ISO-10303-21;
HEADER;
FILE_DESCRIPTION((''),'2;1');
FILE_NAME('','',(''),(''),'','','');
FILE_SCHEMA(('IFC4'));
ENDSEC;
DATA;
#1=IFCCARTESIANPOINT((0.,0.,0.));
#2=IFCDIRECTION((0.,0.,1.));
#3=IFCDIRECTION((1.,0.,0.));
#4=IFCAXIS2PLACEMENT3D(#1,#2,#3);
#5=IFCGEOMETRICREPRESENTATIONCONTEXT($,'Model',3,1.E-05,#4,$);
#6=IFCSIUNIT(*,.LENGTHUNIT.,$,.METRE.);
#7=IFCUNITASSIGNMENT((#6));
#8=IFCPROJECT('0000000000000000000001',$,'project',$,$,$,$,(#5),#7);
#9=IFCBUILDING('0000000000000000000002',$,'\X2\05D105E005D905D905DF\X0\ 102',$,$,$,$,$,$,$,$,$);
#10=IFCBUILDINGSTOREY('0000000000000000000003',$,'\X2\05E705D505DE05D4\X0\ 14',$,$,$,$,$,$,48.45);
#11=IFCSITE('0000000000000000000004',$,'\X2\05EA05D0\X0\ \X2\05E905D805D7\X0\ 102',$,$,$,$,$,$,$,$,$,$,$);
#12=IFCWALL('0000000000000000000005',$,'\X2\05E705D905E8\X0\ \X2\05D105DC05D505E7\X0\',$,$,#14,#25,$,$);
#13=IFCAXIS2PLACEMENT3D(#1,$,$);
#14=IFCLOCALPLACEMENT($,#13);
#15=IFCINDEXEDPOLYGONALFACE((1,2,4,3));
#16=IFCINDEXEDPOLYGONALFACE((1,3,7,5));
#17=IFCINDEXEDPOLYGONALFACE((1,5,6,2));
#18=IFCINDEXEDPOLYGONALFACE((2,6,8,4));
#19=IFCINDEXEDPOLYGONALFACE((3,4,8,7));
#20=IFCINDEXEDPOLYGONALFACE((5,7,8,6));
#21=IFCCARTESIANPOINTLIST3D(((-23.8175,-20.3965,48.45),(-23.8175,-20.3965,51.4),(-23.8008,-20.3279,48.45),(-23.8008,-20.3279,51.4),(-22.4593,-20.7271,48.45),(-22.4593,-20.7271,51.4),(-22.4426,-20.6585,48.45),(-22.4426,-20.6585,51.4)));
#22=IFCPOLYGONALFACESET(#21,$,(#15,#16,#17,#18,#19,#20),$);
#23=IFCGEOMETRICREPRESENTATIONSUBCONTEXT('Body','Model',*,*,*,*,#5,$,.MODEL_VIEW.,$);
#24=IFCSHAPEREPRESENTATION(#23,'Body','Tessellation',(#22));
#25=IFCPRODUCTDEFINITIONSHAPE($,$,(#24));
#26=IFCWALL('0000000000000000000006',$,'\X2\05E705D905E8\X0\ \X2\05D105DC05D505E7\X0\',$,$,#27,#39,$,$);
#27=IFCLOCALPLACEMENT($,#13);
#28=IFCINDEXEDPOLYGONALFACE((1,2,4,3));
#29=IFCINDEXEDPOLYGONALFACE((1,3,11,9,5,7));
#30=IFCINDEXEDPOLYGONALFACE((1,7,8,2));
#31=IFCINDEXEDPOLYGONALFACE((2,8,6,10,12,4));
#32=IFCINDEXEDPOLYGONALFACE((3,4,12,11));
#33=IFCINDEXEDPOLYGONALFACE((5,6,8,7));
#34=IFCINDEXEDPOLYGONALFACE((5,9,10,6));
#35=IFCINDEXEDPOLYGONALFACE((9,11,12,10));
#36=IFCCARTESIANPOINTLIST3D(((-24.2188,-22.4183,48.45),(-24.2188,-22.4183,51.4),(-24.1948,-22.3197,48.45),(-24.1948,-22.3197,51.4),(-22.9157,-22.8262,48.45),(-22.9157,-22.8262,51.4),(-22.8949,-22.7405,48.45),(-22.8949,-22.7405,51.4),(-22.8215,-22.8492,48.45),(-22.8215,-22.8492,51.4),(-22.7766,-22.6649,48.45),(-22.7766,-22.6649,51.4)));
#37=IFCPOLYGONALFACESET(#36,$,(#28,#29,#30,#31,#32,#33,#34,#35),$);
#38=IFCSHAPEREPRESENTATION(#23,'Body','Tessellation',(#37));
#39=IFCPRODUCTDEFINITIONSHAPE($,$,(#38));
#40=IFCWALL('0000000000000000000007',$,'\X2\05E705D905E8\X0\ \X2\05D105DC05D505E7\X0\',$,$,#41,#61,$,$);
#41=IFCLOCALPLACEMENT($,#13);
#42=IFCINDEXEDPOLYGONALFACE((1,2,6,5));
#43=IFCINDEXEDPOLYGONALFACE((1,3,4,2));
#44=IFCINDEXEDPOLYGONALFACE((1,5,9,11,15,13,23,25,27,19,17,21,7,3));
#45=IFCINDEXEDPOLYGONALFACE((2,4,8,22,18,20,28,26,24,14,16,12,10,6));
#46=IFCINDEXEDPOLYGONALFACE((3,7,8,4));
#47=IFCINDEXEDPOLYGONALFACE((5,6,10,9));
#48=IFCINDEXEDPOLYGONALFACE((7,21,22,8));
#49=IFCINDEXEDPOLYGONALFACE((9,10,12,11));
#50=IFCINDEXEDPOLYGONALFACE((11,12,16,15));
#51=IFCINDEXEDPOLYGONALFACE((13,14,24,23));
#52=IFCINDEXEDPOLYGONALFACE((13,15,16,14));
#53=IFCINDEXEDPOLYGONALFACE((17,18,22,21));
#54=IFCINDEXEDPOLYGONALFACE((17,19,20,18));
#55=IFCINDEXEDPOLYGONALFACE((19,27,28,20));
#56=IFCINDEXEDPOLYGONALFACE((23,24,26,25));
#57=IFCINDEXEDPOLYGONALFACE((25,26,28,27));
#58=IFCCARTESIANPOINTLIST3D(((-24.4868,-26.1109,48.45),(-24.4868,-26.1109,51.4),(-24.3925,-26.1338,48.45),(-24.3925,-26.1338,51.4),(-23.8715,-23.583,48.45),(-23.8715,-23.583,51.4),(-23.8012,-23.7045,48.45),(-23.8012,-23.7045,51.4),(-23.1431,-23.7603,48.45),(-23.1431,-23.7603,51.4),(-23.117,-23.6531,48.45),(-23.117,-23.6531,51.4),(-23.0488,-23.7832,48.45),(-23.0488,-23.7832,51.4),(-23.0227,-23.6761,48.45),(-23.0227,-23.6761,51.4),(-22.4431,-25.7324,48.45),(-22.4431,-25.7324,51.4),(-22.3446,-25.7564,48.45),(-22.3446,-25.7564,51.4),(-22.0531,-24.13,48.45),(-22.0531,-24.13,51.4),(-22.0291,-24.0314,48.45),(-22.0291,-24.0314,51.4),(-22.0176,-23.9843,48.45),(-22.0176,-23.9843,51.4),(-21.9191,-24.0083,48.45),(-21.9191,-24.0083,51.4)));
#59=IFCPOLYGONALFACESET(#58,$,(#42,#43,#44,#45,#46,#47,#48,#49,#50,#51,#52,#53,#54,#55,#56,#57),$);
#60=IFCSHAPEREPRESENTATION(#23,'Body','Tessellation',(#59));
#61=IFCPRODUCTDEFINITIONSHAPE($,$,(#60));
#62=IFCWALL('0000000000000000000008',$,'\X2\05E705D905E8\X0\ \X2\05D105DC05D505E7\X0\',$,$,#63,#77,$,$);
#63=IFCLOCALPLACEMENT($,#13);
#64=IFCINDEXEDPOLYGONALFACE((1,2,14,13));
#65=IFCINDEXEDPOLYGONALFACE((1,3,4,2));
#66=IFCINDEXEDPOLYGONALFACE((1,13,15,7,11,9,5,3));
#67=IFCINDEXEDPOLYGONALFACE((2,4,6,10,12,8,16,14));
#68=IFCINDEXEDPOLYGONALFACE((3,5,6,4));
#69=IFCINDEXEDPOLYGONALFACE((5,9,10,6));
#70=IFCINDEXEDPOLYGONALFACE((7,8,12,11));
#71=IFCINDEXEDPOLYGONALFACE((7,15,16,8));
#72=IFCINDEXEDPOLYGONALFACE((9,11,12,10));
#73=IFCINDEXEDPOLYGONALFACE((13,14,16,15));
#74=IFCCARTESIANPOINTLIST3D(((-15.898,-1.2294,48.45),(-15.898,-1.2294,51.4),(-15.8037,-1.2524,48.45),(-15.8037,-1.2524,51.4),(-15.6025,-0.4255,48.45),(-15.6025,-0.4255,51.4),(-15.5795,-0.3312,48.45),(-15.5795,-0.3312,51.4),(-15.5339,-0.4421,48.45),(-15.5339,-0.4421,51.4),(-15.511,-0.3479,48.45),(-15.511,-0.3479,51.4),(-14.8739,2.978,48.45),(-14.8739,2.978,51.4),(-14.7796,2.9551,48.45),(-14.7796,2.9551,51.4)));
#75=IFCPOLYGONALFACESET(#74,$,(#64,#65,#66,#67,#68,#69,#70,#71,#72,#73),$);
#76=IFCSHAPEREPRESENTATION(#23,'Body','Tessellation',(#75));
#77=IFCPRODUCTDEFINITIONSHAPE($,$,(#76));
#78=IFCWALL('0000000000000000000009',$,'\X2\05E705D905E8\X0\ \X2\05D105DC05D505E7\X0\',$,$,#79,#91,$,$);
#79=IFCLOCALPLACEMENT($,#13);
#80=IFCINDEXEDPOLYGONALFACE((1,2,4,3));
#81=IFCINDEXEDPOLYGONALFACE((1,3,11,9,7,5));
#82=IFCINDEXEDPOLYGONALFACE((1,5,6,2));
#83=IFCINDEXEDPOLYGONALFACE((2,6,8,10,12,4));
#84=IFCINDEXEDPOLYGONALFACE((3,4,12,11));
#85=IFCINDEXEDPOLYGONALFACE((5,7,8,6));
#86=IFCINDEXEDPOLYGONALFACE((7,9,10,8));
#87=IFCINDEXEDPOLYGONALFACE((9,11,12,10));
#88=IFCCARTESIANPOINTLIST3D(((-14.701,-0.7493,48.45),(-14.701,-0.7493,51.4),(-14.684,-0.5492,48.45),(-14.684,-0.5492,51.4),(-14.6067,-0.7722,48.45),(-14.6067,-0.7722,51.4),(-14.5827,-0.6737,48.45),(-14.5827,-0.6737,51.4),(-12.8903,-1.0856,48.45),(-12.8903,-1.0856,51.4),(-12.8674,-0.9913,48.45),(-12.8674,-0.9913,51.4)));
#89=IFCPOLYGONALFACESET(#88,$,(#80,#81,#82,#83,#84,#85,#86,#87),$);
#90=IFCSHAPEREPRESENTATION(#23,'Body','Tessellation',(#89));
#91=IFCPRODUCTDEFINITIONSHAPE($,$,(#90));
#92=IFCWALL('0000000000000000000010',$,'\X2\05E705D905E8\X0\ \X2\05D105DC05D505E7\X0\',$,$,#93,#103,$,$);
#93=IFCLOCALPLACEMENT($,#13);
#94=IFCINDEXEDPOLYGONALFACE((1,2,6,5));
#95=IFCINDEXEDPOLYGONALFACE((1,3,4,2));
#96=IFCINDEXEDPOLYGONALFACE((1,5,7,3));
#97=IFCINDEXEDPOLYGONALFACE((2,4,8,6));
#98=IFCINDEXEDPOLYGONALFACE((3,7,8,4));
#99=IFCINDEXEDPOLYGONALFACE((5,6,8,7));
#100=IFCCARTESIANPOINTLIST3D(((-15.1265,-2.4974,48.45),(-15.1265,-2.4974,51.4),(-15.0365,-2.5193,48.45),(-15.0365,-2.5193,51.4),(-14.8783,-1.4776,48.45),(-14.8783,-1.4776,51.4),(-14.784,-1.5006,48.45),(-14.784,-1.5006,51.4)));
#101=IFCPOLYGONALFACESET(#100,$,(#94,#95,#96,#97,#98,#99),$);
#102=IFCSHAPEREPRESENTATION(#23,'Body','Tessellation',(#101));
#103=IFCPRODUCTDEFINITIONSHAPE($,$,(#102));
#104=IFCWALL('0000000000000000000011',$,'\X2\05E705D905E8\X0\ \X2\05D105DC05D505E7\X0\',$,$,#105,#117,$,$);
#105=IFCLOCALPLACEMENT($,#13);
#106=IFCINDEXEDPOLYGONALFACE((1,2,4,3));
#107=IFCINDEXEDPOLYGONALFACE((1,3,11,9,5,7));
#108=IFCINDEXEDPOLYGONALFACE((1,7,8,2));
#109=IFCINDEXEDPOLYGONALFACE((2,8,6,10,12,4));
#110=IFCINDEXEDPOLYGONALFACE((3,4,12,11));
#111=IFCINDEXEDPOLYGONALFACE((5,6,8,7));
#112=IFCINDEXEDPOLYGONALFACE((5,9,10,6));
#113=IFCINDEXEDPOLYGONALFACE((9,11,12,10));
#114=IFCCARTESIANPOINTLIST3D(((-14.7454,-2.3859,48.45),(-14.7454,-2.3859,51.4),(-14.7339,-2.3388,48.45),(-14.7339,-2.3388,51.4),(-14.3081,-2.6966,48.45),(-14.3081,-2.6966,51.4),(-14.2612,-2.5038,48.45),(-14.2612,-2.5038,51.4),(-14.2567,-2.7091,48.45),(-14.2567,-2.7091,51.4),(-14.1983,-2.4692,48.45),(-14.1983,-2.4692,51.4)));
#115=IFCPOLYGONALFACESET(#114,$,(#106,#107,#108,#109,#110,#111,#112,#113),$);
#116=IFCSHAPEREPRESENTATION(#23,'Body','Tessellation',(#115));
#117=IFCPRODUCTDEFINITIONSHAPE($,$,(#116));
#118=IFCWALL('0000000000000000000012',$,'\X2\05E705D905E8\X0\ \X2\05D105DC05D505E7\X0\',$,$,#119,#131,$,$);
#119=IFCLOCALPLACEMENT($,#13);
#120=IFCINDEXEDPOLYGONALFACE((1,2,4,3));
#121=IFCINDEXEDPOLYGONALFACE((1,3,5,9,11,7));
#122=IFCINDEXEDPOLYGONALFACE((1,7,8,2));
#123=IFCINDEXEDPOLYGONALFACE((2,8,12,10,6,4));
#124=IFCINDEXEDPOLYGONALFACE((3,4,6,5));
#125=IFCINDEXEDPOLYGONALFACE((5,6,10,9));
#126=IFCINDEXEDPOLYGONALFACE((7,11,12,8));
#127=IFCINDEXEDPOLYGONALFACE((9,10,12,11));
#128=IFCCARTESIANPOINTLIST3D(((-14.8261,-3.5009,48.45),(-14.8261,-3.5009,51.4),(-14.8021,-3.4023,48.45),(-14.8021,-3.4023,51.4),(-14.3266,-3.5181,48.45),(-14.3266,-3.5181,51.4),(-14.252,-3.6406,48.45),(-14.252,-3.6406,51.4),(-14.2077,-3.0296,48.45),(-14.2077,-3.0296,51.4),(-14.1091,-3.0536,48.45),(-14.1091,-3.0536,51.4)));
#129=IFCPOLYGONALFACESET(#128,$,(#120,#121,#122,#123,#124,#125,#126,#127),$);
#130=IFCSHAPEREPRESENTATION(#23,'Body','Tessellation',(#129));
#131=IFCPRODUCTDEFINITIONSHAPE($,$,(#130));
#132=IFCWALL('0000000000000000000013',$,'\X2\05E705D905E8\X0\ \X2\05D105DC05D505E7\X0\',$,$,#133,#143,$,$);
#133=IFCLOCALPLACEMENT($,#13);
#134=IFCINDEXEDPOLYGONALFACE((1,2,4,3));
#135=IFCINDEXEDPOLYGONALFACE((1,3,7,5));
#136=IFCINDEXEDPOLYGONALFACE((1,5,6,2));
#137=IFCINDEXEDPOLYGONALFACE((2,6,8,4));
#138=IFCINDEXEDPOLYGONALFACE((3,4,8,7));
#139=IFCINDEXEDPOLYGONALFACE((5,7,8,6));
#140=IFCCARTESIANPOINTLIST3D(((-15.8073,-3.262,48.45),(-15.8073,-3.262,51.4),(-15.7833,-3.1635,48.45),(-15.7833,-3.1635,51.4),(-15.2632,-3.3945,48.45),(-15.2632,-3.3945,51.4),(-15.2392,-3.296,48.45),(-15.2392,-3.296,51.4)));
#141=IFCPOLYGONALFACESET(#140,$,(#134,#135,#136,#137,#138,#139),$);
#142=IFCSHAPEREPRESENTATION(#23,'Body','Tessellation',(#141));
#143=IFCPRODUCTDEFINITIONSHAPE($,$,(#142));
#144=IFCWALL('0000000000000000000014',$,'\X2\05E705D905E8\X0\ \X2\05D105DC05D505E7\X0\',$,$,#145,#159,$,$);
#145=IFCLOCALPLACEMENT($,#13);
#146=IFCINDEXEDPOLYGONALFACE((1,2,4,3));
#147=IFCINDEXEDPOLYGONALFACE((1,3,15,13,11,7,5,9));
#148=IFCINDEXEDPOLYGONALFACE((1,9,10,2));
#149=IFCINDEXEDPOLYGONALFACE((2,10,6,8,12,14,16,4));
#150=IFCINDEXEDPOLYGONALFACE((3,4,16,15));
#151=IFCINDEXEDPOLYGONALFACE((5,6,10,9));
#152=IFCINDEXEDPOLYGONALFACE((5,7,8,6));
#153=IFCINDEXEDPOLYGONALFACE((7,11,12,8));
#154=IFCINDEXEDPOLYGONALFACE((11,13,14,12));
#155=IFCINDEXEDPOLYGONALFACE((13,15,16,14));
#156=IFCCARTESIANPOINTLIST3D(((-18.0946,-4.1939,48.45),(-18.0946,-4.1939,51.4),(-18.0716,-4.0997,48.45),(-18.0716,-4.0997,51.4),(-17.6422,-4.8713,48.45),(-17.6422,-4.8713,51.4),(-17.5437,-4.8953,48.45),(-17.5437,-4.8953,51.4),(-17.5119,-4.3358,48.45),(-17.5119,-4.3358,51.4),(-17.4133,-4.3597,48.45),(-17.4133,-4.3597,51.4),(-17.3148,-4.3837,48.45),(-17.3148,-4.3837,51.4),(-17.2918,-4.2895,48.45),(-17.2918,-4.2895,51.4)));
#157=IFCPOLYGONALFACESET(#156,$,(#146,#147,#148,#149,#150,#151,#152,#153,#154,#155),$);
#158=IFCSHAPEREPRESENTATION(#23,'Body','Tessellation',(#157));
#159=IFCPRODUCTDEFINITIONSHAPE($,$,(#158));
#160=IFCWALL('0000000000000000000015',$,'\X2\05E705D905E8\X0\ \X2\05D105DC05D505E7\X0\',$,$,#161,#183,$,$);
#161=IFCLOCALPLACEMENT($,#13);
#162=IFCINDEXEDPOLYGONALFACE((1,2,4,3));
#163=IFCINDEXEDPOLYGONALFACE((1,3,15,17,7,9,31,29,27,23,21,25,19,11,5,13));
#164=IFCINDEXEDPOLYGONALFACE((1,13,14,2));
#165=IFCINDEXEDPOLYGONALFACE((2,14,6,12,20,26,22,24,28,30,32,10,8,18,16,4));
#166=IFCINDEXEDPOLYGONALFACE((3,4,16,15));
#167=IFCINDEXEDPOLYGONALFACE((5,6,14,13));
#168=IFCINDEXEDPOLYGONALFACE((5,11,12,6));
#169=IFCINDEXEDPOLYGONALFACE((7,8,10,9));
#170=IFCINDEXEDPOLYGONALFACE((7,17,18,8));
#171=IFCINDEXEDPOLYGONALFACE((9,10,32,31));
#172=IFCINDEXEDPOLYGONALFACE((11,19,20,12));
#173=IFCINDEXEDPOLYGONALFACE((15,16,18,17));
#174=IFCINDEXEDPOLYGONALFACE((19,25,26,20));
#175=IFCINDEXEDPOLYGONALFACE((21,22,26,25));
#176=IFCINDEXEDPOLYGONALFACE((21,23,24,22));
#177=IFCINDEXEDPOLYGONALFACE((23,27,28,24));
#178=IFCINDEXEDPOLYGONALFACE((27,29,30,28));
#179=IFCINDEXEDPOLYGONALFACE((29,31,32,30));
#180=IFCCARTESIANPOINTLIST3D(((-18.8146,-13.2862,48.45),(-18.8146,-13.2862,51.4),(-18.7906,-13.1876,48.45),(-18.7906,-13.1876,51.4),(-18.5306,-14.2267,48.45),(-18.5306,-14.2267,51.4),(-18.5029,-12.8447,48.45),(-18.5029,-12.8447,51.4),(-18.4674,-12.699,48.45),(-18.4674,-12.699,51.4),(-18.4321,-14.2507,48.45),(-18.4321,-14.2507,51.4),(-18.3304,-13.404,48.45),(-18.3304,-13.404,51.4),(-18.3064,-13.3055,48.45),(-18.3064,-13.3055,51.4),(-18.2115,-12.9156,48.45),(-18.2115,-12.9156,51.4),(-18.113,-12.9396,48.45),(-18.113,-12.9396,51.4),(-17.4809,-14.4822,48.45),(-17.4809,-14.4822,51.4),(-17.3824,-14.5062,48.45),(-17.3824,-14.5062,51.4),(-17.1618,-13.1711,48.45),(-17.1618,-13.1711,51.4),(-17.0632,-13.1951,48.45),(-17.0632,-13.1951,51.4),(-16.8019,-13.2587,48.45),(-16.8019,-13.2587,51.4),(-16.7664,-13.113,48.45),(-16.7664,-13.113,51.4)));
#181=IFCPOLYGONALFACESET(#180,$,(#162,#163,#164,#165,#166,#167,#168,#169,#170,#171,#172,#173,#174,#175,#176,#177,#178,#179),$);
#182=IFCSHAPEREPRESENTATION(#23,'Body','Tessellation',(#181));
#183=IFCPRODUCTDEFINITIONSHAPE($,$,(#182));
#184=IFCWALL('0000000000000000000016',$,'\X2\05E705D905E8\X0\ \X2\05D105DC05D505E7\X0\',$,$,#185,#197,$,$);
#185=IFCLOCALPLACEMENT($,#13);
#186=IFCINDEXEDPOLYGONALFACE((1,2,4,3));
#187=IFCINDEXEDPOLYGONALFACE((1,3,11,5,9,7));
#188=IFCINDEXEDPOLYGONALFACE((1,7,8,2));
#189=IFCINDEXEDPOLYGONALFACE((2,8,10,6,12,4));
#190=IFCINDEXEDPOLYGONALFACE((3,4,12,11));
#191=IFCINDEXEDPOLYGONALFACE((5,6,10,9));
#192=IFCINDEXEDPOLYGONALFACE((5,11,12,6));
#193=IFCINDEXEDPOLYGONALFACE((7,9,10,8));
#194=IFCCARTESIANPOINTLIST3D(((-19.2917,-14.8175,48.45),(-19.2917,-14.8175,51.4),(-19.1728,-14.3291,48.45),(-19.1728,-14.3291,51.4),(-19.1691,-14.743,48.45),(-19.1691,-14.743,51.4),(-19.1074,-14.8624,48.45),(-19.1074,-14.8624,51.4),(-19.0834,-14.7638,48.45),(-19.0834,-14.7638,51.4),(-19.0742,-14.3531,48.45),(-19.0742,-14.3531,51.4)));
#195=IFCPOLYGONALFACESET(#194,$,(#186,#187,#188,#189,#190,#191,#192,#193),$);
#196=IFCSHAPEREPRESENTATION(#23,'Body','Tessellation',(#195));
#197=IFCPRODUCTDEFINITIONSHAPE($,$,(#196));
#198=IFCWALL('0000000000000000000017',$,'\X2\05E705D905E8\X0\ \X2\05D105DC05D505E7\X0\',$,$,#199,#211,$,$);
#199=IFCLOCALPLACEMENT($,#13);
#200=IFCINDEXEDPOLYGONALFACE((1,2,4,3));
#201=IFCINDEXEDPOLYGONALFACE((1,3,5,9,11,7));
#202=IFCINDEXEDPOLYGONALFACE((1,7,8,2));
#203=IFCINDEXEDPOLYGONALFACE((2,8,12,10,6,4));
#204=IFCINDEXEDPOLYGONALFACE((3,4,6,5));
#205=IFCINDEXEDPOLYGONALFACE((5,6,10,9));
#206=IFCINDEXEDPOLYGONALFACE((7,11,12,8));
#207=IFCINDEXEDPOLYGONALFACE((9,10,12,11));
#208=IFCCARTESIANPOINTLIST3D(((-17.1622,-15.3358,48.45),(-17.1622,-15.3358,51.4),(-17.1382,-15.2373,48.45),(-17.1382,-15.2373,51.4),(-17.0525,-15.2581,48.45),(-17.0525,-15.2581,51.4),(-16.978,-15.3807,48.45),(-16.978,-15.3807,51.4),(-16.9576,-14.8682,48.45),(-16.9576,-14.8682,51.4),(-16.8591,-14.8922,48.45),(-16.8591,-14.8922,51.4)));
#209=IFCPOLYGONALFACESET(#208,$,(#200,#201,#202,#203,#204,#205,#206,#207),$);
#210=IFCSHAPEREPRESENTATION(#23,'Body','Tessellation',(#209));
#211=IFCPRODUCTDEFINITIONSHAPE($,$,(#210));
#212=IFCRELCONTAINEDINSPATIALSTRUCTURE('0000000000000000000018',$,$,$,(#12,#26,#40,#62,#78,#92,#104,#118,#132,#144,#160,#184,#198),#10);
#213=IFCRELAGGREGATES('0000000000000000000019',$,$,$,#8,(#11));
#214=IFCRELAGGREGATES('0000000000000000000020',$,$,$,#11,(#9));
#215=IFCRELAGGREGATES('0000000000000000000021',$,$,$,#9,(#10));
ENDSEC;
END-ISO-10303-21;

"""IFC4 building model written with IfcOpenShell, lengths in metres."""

from ifc_helpers import new_model, si_unit, frame, origin_with_axes, context, subcontext, project, spatial, polyline, outline, extrude, element, save


model = new_model("IFC4")

# Units and contexts
model_context = context("Model", 3, precision=1e-05, world=origin_with_axes())
body_context = subcontext(model_context, "Body", "Model", "MODEL_VIEW")
ifc_project = project(units=[si_unit("LENGTHUNIT", "METRE")], contexts=[model_context])

# Site, building, storey
site = spatial("IfcSite", under=ifc_project, Name="תא שטח 102")
building = spatial("IfcBuilding", under=site, Name="בניין 102")
storey = spatial("IfcBuildingStorey", under=building, Name="קומה 14", Elevation=48.45)

# Walls
element("IfcWall", 1, inside=storey, Name="קיר בלוק", context=body_context, shape_type="SweptSolid", body=[
    extrude(outline(polyline([(-22.4426, -20.6585), (-23.8008, -20.3279), (-23.8175, -20.3965), (-22.4593, -20.7271), (-22.4426, -20.6585)])), frame((0.0, 0.0, 48.45)), (0.0, 0.0, 1.0), 2.95),
])
element("IfcWall", 2, inside=storey, Name="קיר בלוק", context=body_context, shape_type="SweptSolid", body=[
    extrude(outline(polyline([(-24.2188, -22.4183), (-22.8949, -22.7405), (-22.9157, -22.8262), (-22.8215, -22.8492), (-22.7766, -22.6649), (-24.1948, -22.3197), (-24.2188, -22.4183)])), frame((0.0, 0.0, 48.45)), (0.0, 0.0, 1.0), 2.95),
])
element("IfcWall", 3, inside=storey, Name="קיר בלוק", context=body_context, shape_type="SweptSolid", body=[
    extrude(outline(polyline([(-23.8012, -23.7045), (-22.0531, -24.13), (-22.4431, -25.7324), (-22.3446, -25.7564), (-21.9191, -24.0083), (-22.0176, -23.9843), (-22.0291, -24.0314), (-23.0488, -23.7832), (-23.0227, -23.6761), (-23.117, -23.6531), (-23.1431, -23.7603), (-23.8715, -23.583), (-24.4868, -26.1109), (-24.3925, -26.1338), (-23.8012, -23.7045)])), frame((0.0, 0.0, 48.45)), (0.0, 0.0, 1.0), 2.95),
])
element("IfcWall", 4, inside=storey, Name="קיר בלוק", context=body_context, shape_type="SweptSolid", body=[
    extrude(outline(polyline([(-14.8739, 2.978), (-15.898, -1.2294), (-15.8037, -1.2524), (-15.6025, -0.4255), (-15.5339, -0.4421), (-15.511, -0.3479), (-15.5795, -0.3312), (-14.7796, 2.9551), (-14.8739, 2.978)])), frame((0.0, 0.0, 48.45)), (0.0, 0.0, 1.0), 2.95),
])
element("IfcWall", 5, inside=storey, Name="קיר בלוק", context=body_context, shape_type="SweptSolid", body=[
    extrude(outline(polyline([(-14.701, -0.7493), (-14.6067, -0.7722), (-14.5827, -0.6737), (-12.8903, -1.0856), (-12.8674, -0.9913), (-14.684, -0.5492), (-14.701, -0.7493)])), frame((0.0, 0.0, 48.45)), (0.0, 0.0, 1.0), 2.95),
])
element("IfcWall", 6, inside=storey, Name="קיר בלוק", context=body_context, shape_type="SweptSolid", body=[
    extrude(outline(polyline([(-15.1265, -2.4974), (-15.0365, -2.5193), (-14.784, -1.5006), (-14.8783, -1.4776), (-15.1265, -2.4974)])), frame((0.0, 0.0, 48.45)), (0.0, 0.0, 1.0), 2.95),
])
element("IfcWall", 7, inside=storey, Name="קיר בלוק", context=body_context, shape_type="SweptSolid", body=[
    extrude(outline(polyline([(-14.7454, -2.3859), (-14.2612, -2.5038), (-14.3081, -2.6966), (-14.2567, -2.7091), (-14.1983, -2.4692), (-14.7339, -2.3388), (-14.7454, -2.3859)])), frame((0.0, 0.0, 48.45)), (0.0, 0.0, 1.0), 2.95),
])
element("IfcWall", 8, inside=storey, Name="קיר בלוק", context=body_context, shape_type="SweptSolid", body=[
    extrude(outline(polyline([(-14.8021, -3.4023), (-14.8261, -3.5009), (-14.252, -3.6406), (-14.1091, -3.0536), (-14.2077, -3.0296), (-14.3266, -3.5181), (-14.8021, -3.4023)])), frame((0.0, 0.0, 48.45)), (0.0, 0.0, 1.0), 2.95),
])
element("IfcWall", 9, inside=storey, Name="קיר בלוק", context=body_context, shape_type="SweptSolid", body=[
    extrude(outline(polyline([(-15.7833, -3.1635), (-15.8073, -3.262), (-15.2632, -3.3945), (-15.2392, -3.296), (-15.7833, -3.1635)])), frame((0.0, 0.0, 48.45)), (0.0, 0.0, 1.0), 2.95),
])
element("IfcWall", 10, inside=storey, Name="קיר בלוק", context=body_context, shape_type="SweptSolid", body=[
    extrude(outline(polyline([(-17.4133, -4.3597), (-17.3148, -4.3837), (-17.2918, -4.2895), (-18.0716, -4.0997), (-18.0946, -4.1939), (-17.5119, -4.3358), (-17.6422, -4.8713), (-17.5437, -4.8953), (-17.4133, -4.3597)])), frame((0.0, 0.0, 48.45)), (0.0, 0.0, 1.0), 2.95),
])
element("IfcWall", 11, inside=storey, Name="קיר בלוק", context=body_context, shape_type="SweptSolid", body=[
    extrude(outline(polyline([(-18.7906, -13.1876), (-18.8146, -13.2862), (-18.3304, -13.404), (-18.5306, -14.2267), (-18.4321, -14.2507), (-18.113, -12.9396), (-17.1618, -13.1711), (-17.4809, -14.4822), (-17.3824, -14.5062), (-17.0632, -13.1951), (-16.8019, -13.2587), (-16.7664, -13.113), (-18.4674, -12.699), (-18.5029, -12.8447), (-18.2115, -12.9156), (-18.3064, -13.3055), (-18.7906, -13.1876)])), frame((0.0, 0.0, 48.45)), (0.0, 0.0, 1.0), 2.95),
])
element("IfcWall", 12, inside=storey, Name="קיר בלוק", context=body_context, shape_type="SweptSolid", body=[
    extrude(outline(polyline([(-19.0834, -14.7638), (-19.1691, -14.743), (-19.0742, -14.3531), (-19.1728, -14.3291), (-19.2917, -14.8175), (-19.1074, -14.8624), (-19.0834, -14.7638)])), frame((0.0, 0.0, 48.45)), (0.0, 0.0, 1.0), 2.95),
])
element("IfcWall", 13, inside=storey, Name="קיר בלוק", context=body_context, shape_type="SweptSolid", body=[
    extrude(outline(polyline([(-16.978, -15.3807), (-16.8591, -14.8922), (-16.9576, -14.8682), (-17.0525, -15.2581), (-17.1382, -15.2373), (-17.1622, -15.3358), (-16.978, -15.3807)])), frame((0.0, 0.0, 48.45)), (0.0, 0.0, 1.0), 2.95),
])

save(model, "model.ifc")
